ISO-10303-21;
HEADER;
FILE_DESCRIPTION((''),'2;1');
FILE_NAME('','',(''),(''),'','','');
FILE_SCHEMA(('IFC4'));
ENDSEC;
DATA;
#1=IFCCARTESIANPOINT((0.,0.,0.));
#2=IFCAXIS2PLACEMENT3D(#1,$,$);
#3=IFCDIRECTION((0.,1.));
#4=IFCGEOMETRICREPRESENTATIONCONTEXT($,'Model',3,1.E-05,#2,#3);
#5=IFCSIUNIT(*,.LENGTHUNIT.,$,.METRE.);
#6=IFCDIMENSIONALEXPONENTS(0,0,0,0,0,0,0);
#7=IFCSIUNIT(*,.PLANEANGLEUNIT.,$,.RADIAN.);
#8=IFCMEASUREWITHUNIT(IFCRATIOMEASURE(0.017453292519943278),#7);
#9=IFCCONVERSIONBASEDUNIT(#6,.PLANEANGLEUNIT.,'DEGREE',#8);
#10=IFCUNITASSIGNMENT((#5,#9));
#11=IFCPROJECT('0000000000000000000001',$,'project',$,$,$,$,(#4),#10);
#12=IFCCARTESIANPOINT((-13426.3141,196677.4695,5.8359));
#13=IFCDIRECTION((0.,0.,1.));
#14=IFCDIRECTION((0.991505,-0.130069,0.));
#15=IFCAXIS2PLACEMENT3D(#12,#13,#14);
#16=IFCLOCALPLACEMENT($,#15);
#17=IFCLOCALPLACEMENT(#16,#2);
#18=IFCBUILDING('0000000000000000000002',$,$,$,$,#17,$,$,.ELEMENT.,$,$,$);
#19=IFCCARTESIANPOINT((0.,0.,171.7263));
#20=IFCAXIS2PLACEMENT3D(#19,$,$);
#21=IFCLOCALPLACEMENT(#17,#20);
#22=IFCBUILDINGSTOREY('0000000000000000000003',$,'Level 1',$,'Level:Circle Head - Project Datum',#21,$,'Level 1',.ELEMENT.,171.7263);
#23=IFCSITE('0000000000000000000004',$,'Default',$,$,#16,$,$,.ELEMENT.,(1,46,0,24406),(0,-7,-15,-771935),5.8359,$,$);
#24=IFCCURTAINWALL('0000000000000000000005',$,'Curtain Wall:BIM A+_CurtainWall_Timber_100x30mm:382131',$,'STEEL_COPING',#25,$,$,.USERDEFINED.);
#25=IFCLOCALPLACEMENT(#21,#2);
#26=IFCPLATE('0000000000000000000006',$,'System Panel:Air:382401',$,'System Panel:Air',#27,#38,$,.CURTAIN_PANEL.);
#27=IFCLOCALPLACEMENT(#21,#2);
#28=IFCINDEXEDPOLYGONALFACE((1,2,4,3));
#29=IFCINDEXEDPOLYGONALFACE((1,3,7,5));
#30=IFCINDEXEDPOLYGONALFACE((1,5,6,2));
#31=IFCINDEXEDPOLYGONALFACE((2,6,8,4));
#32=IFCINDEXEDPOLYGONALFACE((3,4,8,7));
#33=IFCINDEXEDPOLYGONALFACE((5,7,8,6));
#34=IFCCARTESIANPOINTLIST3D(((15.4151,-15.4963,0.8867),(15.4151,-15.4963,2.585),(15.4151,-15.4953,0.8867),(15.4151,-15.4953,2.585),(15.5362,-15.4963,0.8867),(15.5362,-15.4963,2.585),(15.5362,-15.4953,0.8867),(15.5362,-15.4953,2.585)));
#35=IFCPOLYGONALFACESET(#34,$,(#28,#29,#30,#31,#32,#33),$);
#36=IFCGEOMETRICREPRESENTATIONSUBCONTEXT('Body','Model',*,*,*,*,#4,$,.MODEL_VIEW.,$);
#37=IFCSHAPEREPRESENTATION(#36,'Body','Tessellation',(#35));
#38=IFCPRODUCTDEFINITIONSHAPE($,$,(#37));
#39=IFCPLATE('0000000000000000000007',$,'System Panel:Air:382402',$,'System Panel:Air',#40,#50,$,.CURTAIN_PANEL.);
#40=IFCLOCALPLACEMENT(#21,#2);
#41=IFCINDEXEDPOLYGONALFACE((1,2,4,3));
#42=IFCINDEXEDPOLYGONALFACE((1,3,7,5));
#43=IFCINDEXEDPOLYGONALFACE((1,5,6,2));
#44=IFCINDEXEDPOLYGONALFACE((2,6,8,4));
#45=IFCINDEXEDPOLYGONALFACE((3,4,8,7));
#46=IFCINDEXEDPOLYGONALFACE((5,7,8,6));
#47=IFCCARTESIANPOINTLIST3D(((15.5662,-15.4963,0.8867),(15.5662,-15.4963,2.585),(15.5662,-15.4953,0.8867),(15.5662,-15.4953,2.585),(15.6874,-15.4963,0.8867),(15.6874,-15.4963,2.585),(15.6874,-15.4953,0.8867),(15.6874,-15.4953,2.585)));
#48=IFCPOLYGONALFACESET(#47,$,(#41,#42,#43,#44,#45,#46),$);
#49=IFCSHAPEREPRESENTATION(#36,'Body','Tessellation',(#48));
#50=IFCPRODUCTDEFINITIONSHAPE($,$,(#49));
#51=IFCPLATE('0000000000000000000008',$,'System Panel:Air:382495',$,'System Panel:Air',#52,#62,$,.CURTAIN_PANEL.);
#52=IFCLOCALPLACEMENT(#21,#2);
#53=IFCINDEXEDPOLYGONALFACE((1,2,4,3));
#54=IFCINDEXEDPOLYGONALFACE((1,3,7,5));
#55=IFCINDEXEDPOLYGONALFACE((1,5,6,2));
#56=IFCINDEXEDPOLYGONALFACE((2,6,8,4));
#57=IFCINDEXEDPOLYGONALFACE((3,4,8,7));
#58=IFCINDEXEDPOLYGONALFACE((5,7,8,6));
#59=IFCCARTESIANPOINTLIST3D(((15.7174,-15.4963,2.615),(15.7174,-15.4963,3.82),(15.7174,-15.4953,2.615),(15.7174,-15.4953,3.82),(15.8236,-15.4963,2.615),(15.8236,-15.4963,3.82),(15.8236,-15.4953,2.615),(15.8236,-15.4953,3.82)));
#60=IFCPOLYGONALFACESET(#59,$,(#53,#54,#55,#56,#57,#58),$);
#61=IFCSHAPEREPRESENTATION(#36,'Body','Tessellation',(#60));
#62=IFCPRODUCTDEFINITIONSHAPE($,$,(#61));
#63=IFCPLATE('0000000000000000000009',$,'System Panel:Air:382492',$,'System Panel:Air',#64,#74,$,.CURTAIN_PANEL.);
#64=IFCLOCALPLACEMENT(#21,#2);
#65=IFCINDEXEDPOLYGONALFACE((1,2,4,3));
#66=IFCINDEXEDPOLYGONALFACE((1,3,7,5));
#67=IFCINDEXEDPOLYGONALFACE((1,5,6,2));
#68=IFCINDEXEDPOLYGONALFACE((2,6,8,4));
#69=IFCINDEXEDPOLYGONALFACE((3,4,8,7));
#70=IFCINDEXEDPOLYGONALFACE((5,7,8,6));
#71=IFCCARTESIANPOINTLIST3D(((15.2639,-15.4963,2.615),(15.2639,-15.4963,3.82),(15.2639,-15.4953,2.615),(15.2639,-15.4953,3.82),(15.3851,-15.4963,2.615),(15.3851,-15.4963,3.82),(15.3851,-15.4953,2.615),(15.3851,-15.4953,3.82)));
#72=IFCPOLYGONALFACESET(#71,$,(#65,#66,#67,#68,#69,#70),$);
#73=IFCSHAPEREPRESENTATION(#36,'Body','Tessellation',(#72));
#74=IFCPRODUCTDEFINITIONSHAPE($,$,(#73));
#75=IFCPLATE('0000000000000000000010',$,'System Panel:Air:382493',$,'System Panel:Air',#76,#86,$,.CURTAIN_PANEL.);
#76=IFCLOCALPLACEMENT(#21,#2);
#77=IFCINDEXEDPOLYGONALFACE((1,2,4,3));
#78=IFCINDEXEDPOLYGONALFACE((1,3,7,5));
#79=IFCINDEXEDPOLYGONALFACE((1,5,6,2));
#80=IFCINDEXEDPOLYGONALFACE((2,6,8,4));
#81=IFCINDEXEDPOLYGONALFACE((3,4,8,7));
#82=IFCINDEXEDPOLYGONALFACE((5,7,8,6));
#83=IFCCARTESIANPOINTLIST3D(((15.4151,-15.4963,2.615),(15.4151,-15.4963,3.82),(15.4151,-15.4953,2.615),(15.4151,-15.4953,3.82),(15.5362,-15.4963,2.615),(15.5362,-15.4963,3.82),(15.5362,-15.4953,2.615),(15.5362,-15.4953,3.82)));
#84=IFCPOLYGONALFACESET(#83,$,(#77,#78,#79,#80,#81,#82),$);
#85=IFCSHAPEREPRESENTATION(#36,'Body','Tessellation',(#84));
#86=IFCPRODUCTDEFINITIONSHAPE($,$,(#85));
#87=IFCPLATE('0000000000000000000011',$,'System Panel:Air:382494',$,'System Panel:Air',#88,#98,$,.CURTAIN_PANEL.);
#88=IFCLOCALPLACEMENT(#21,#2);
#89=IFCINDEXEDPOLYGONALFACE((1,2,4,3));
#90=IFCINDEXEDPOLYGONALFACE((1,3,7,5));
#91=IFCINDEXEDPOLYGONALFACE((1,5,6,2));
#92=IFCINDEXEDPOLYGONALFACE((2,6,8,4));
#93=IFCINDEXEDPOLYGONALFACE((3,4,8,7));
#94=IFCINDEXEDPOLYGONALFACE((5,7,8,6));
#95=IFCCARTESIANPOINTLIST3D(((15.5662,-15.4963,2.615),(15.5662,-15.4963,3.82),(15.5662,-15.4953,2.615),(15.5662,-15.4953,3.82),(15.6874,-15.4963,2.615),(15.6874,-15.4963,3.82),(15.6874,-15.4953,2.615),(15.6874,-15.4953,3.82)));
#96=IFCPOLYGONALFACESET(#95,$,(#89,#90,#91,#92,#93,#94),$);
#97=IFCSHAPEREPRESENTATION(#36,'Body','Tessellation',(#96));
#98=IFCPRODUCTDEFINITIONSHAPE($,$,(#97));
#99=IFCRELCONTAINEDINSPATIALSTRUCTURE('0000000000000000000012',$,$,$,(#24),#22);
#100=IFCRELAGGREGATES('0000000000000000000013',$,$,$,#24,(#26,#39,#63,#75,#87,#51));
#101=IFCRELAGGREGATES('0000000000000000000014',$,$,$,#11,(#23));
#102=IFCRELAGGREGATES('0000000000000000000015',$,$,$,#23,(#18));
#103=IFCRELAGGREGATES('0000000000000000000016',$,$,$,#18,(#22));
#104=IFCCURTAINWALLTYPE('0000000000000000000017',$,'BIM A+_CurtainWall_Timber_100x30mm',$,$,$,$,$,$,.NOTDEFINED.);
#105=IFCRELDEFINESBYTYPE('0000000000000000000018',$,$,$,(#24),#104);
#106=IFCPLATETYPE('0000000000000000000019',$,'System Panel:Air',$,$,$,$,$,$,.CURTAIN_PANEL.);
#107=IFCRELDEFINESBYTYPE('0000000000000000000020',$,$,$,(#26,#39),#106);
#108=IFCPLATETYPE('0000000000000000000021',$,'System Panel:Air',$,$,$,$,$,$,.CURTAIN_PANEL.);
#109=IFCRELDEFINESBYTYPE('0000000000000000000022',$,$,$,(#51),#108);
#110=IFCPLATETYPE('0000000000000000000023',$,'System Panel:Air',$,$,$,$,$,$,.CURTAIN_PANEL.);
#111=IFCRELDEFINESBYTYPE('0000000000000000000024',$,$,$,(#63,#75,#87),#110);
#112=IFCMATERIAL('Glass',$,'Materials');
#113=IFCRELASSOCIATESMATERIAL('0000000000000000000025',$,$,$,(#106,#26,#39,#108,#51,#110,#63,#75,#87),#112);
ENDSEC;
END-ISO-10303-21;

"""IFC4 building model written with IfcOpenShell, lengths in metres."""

from ifc_helpers import new_model, entity, si_unit, converted_unit, direction, frame, origin, place, context, subcontext, project, spatial, indexed_curve, outline, extrude, source, transform, mapped, material, type_object, type_shapes, element, aggregate, save


model = new_model("IFC4")

# Units and contexts
model_context = context("Model", 3, precision=1e-05, world=origin(), true_north=direction((0.0, 1.0)))
body_context = subcontext(model_context, "Body", "Model", "MODEL_VIEW")
ifc_project = project(units=[si_unit("LENGTHUNIT", "METRE"), converted_unit("PLANEANGLEUNIT", "DEGREE", entity("IfcRatioMeasure", 0.017453292519943278), si_unit("PLANEANGLEUNIT", "RADIAN"), dimensions=[0, 0, 0, 0, 0, 0, 0])], contexts=[model_context])

# Site, building, storey
site_placement = place(None, frame((-13426.3141, 196677.4695, 5.8359), z_axis=(0.0, 0.0, 1.0), x_axis=(0.991505, -0.130069, 0.0)))
site = spatial("IfcSite", under=ifc_project, at=site_placement, Name="Default", CompositionType="ELEMENT", RefLatitude=(1, 46, 0, 24406), RefLongitude=(0, -7, -15, -771935), RefElevation=5.8359)
building_placement = place(site_placement, origin())
building = spatial("IfcBuilding", under=site, at=building_placement, CompositionType="ELEMENT")
storey_placement = place(building_placement, frame((0.0, 0.0, 171.7263)))
storey = spatial("IfcBuildingStorey", under=building, at=storey_placement, Name="Level 1", ObjectType="Level:Circle Head - Project Datum", LongName="Level 1", CompositionType="ELEMENT", Elevation=171.7263)

# Curtain wall
curtain_wall_type_1 = type_object("IfcCurtainWallType", Name="BIM A+_CurtainWall_Timber_100x30mm", PredefinedType="NOTDEFINED")
curtain_wall_1_placement = place(storey_placement, frame((0.0, 0.0, -171.7263)))
curtain_wall_1 = element("IfcCurtainWall", 1, at=curtain_wall_1_placement, inside=storey, type_object=curtain_wall_type_1, Name="Curtain Wall:BIM A+_CurtainWall_Timber_100x30mm:382131", ObjectType="STEEL_COPING", PredefinedType="USERDEFINED")

# Plates
ifc_material_1 = material(Name="Glass", Category="Materials")
plate_type_1 = type_object("IfcPlateType", Name="System Panel:Air", PredefinedType="CURTAIN_PANEL", material=ifc_material_1)
shared_shape_1 = source(origin(), body_context, "Body", "SweptSolid", [
    extrude(outline(indexed_curve([(-0.0005, -0.0606), (0.0005, -0.0606), (0.0005, 0.0606), (-0.0005, 0.0606), (-0.0005, -0.0606)], self_intersect=False)), frame((0.0, 0.0, 0.0), z_axis=(0.0, 0.0, 1.0), x_axis=(0.0, 1.0, 0.0)), (0.0, 0.0, 1.0), 1.6983),
])
type_shapes(plate_type_1, [shared_shape_1])
plate_1_placement = place(curtain_wall_1_placement, frame((15.4757, -15.4958, 172.613)))
plate_1 = element("IfcPlate", 2, at=plate_1_placement, type_object=plate_type_1, material=ifc_material_1, Name="System Panel:Air:382401", ObjectType="System Panel:Air", PredefinedType="CURTAIN_PANEL", context=body_context, shape_type="MappedRepresentation", body=[
    mapped(shared_shape_1, transform((0.0, 0.0, 0.0), scale=1.0)),
])
plate_2_placement = place(curtain_wall_1_placement, frame((15.6268, -15.4958, 172.613)))
plate_2 = element("IfcPlate", 3, at=plate_2_placement, type_object=plate_type_1, material=ifc_material_1, Name="System Panel:Air:382402", ObjectType="System Panel:Air", PredefinedType="CURTAIN_PANEL", context=body_context, shape_type="MappedRepresentation", body=[
    mapped(shared_shape_1, transform((0.0, 0.0, 0.0), scale=1.0)),
])
plate_type_2 = type_object("IfcPlateType", Name="System Panel:Air", PredefinedType="CURTAIN_PANEL", material=ifc_material_1)
shared_shape_2 = source(origin(), body_context, "Body", "SweptSolid", [
    extrude(outline(indexed_curve([(-0.0005, -0.0531), (0.0005, -0.0531), (0.0005, 0.0531), (-0.0005, 0.0531), (-0.0005, -0.0531)], self_intersect=False)), frame((0.0, 0.0, 0.0), z_axis=(0.0, 0.0, 1.0), x_axis=(0.0, 1.0, 0.0)), (0.0, 0.0, 1.0), 1.205),
])
type_shapes(plate_type_2, [shared_shape_2])
plate_3_placement = place(curtain_wall_1_placement, frame((15.7705, -15.4958, 174.3413)))
plate_3 = element("IfcPlate", 4, at=plate_3_placement, type_object=plate_type_2, material=ifc_material_1, Name="System Panel:Air:382495", ObjectType="System Panel:Air", PredefinedType="CURTAIN_PANEL", context=body_context, shape_type="MappedRepresentation", body=[
    mapped(shared_shape_2, transform((0.0, 0.0, 0.0), scale=1.0)),
])
plate_type_3 = type_object("IfcPlateType", Name="System Panel:Air", PredefinedType="CURTAIN_PANEL", material=ifc_material_1)
shared_shape_3 = source(origin(), body_context, "Body", "SweptSolid", [
    extrude(outline(indexed_curve([(-0.0005, -0.0606), (0.0005, -0.0606), (0.0005, 0.0606), (-0.0005, 0.0606), (-0.0005, -0.0606)], self_intersect=False)), frame((0.0, 0.0, 0.0), z_axis=(0.0, 0.0, 1.0), x_axis=(0.0, 1.0, 0.0)), (0.0, 0.0, 1.0), 1.205),
])
type_shapes(plate_type_3, [shared_shape_3])
plate_4_placement = place(curtain_wall_1_placement, frame((15.3245, -15.4958, 174.3413)))
plate_4 = element("IfcPlate", 5, at=plate_4_placement, type_object=plate_type_3, material=ifc_material_1, Name="System Panel:Air:382492", ObjectType="System Panel:Air", PredefinedType="CURTAIN_PANEL", context=body_context, shape_type="MappedRepresentation", body=[
    mapped(shared_shape_3, transform((0.0, 0.0, 0.0), scale=1.0)),
])
plate_5_placement = place(curtain_wall_1_placement, frame((15.4757, -15.4958, 174.3413)))
plate_5 = element("IfcPlate", 6, at=plate_5_placement, type_object=plate_type_3, material=ifc_material_1, Name="System Panel:Air:382493", ObjectType="System Panel:Air", PredefinedType="CURTAIN_PANEL", context=body_context, shape_type="MappedRepresentation", body=[
    mapped(shared_shape_3, transform((0.0, 0.0, 0.0), scale=1.0)),
])
plate_6_placement = place(curtain_wall_1_placement, frame((15.6268, -15.4958, 174.3413)))
plate_6 = element("IfcPlate", 7, at=plate_6_placement, type_object=plate_type_3, material=ifc_material_1, Name="System Panel:Air:382494", ObjectType="System Panel:Air", PredefinedType="CURTAIN_PANEL", context=body_context, shape_type="MappedRepresentation", body=[
    mapped(shared_shape_3, transform((0.0, 0.0, 0.0), scale=1.0)),
])
aggregate(curtain_wall_1, [plate_1, plate_2, plate_4, plate_5, plate_6, plate_3])

save(model, "model.ifc")
